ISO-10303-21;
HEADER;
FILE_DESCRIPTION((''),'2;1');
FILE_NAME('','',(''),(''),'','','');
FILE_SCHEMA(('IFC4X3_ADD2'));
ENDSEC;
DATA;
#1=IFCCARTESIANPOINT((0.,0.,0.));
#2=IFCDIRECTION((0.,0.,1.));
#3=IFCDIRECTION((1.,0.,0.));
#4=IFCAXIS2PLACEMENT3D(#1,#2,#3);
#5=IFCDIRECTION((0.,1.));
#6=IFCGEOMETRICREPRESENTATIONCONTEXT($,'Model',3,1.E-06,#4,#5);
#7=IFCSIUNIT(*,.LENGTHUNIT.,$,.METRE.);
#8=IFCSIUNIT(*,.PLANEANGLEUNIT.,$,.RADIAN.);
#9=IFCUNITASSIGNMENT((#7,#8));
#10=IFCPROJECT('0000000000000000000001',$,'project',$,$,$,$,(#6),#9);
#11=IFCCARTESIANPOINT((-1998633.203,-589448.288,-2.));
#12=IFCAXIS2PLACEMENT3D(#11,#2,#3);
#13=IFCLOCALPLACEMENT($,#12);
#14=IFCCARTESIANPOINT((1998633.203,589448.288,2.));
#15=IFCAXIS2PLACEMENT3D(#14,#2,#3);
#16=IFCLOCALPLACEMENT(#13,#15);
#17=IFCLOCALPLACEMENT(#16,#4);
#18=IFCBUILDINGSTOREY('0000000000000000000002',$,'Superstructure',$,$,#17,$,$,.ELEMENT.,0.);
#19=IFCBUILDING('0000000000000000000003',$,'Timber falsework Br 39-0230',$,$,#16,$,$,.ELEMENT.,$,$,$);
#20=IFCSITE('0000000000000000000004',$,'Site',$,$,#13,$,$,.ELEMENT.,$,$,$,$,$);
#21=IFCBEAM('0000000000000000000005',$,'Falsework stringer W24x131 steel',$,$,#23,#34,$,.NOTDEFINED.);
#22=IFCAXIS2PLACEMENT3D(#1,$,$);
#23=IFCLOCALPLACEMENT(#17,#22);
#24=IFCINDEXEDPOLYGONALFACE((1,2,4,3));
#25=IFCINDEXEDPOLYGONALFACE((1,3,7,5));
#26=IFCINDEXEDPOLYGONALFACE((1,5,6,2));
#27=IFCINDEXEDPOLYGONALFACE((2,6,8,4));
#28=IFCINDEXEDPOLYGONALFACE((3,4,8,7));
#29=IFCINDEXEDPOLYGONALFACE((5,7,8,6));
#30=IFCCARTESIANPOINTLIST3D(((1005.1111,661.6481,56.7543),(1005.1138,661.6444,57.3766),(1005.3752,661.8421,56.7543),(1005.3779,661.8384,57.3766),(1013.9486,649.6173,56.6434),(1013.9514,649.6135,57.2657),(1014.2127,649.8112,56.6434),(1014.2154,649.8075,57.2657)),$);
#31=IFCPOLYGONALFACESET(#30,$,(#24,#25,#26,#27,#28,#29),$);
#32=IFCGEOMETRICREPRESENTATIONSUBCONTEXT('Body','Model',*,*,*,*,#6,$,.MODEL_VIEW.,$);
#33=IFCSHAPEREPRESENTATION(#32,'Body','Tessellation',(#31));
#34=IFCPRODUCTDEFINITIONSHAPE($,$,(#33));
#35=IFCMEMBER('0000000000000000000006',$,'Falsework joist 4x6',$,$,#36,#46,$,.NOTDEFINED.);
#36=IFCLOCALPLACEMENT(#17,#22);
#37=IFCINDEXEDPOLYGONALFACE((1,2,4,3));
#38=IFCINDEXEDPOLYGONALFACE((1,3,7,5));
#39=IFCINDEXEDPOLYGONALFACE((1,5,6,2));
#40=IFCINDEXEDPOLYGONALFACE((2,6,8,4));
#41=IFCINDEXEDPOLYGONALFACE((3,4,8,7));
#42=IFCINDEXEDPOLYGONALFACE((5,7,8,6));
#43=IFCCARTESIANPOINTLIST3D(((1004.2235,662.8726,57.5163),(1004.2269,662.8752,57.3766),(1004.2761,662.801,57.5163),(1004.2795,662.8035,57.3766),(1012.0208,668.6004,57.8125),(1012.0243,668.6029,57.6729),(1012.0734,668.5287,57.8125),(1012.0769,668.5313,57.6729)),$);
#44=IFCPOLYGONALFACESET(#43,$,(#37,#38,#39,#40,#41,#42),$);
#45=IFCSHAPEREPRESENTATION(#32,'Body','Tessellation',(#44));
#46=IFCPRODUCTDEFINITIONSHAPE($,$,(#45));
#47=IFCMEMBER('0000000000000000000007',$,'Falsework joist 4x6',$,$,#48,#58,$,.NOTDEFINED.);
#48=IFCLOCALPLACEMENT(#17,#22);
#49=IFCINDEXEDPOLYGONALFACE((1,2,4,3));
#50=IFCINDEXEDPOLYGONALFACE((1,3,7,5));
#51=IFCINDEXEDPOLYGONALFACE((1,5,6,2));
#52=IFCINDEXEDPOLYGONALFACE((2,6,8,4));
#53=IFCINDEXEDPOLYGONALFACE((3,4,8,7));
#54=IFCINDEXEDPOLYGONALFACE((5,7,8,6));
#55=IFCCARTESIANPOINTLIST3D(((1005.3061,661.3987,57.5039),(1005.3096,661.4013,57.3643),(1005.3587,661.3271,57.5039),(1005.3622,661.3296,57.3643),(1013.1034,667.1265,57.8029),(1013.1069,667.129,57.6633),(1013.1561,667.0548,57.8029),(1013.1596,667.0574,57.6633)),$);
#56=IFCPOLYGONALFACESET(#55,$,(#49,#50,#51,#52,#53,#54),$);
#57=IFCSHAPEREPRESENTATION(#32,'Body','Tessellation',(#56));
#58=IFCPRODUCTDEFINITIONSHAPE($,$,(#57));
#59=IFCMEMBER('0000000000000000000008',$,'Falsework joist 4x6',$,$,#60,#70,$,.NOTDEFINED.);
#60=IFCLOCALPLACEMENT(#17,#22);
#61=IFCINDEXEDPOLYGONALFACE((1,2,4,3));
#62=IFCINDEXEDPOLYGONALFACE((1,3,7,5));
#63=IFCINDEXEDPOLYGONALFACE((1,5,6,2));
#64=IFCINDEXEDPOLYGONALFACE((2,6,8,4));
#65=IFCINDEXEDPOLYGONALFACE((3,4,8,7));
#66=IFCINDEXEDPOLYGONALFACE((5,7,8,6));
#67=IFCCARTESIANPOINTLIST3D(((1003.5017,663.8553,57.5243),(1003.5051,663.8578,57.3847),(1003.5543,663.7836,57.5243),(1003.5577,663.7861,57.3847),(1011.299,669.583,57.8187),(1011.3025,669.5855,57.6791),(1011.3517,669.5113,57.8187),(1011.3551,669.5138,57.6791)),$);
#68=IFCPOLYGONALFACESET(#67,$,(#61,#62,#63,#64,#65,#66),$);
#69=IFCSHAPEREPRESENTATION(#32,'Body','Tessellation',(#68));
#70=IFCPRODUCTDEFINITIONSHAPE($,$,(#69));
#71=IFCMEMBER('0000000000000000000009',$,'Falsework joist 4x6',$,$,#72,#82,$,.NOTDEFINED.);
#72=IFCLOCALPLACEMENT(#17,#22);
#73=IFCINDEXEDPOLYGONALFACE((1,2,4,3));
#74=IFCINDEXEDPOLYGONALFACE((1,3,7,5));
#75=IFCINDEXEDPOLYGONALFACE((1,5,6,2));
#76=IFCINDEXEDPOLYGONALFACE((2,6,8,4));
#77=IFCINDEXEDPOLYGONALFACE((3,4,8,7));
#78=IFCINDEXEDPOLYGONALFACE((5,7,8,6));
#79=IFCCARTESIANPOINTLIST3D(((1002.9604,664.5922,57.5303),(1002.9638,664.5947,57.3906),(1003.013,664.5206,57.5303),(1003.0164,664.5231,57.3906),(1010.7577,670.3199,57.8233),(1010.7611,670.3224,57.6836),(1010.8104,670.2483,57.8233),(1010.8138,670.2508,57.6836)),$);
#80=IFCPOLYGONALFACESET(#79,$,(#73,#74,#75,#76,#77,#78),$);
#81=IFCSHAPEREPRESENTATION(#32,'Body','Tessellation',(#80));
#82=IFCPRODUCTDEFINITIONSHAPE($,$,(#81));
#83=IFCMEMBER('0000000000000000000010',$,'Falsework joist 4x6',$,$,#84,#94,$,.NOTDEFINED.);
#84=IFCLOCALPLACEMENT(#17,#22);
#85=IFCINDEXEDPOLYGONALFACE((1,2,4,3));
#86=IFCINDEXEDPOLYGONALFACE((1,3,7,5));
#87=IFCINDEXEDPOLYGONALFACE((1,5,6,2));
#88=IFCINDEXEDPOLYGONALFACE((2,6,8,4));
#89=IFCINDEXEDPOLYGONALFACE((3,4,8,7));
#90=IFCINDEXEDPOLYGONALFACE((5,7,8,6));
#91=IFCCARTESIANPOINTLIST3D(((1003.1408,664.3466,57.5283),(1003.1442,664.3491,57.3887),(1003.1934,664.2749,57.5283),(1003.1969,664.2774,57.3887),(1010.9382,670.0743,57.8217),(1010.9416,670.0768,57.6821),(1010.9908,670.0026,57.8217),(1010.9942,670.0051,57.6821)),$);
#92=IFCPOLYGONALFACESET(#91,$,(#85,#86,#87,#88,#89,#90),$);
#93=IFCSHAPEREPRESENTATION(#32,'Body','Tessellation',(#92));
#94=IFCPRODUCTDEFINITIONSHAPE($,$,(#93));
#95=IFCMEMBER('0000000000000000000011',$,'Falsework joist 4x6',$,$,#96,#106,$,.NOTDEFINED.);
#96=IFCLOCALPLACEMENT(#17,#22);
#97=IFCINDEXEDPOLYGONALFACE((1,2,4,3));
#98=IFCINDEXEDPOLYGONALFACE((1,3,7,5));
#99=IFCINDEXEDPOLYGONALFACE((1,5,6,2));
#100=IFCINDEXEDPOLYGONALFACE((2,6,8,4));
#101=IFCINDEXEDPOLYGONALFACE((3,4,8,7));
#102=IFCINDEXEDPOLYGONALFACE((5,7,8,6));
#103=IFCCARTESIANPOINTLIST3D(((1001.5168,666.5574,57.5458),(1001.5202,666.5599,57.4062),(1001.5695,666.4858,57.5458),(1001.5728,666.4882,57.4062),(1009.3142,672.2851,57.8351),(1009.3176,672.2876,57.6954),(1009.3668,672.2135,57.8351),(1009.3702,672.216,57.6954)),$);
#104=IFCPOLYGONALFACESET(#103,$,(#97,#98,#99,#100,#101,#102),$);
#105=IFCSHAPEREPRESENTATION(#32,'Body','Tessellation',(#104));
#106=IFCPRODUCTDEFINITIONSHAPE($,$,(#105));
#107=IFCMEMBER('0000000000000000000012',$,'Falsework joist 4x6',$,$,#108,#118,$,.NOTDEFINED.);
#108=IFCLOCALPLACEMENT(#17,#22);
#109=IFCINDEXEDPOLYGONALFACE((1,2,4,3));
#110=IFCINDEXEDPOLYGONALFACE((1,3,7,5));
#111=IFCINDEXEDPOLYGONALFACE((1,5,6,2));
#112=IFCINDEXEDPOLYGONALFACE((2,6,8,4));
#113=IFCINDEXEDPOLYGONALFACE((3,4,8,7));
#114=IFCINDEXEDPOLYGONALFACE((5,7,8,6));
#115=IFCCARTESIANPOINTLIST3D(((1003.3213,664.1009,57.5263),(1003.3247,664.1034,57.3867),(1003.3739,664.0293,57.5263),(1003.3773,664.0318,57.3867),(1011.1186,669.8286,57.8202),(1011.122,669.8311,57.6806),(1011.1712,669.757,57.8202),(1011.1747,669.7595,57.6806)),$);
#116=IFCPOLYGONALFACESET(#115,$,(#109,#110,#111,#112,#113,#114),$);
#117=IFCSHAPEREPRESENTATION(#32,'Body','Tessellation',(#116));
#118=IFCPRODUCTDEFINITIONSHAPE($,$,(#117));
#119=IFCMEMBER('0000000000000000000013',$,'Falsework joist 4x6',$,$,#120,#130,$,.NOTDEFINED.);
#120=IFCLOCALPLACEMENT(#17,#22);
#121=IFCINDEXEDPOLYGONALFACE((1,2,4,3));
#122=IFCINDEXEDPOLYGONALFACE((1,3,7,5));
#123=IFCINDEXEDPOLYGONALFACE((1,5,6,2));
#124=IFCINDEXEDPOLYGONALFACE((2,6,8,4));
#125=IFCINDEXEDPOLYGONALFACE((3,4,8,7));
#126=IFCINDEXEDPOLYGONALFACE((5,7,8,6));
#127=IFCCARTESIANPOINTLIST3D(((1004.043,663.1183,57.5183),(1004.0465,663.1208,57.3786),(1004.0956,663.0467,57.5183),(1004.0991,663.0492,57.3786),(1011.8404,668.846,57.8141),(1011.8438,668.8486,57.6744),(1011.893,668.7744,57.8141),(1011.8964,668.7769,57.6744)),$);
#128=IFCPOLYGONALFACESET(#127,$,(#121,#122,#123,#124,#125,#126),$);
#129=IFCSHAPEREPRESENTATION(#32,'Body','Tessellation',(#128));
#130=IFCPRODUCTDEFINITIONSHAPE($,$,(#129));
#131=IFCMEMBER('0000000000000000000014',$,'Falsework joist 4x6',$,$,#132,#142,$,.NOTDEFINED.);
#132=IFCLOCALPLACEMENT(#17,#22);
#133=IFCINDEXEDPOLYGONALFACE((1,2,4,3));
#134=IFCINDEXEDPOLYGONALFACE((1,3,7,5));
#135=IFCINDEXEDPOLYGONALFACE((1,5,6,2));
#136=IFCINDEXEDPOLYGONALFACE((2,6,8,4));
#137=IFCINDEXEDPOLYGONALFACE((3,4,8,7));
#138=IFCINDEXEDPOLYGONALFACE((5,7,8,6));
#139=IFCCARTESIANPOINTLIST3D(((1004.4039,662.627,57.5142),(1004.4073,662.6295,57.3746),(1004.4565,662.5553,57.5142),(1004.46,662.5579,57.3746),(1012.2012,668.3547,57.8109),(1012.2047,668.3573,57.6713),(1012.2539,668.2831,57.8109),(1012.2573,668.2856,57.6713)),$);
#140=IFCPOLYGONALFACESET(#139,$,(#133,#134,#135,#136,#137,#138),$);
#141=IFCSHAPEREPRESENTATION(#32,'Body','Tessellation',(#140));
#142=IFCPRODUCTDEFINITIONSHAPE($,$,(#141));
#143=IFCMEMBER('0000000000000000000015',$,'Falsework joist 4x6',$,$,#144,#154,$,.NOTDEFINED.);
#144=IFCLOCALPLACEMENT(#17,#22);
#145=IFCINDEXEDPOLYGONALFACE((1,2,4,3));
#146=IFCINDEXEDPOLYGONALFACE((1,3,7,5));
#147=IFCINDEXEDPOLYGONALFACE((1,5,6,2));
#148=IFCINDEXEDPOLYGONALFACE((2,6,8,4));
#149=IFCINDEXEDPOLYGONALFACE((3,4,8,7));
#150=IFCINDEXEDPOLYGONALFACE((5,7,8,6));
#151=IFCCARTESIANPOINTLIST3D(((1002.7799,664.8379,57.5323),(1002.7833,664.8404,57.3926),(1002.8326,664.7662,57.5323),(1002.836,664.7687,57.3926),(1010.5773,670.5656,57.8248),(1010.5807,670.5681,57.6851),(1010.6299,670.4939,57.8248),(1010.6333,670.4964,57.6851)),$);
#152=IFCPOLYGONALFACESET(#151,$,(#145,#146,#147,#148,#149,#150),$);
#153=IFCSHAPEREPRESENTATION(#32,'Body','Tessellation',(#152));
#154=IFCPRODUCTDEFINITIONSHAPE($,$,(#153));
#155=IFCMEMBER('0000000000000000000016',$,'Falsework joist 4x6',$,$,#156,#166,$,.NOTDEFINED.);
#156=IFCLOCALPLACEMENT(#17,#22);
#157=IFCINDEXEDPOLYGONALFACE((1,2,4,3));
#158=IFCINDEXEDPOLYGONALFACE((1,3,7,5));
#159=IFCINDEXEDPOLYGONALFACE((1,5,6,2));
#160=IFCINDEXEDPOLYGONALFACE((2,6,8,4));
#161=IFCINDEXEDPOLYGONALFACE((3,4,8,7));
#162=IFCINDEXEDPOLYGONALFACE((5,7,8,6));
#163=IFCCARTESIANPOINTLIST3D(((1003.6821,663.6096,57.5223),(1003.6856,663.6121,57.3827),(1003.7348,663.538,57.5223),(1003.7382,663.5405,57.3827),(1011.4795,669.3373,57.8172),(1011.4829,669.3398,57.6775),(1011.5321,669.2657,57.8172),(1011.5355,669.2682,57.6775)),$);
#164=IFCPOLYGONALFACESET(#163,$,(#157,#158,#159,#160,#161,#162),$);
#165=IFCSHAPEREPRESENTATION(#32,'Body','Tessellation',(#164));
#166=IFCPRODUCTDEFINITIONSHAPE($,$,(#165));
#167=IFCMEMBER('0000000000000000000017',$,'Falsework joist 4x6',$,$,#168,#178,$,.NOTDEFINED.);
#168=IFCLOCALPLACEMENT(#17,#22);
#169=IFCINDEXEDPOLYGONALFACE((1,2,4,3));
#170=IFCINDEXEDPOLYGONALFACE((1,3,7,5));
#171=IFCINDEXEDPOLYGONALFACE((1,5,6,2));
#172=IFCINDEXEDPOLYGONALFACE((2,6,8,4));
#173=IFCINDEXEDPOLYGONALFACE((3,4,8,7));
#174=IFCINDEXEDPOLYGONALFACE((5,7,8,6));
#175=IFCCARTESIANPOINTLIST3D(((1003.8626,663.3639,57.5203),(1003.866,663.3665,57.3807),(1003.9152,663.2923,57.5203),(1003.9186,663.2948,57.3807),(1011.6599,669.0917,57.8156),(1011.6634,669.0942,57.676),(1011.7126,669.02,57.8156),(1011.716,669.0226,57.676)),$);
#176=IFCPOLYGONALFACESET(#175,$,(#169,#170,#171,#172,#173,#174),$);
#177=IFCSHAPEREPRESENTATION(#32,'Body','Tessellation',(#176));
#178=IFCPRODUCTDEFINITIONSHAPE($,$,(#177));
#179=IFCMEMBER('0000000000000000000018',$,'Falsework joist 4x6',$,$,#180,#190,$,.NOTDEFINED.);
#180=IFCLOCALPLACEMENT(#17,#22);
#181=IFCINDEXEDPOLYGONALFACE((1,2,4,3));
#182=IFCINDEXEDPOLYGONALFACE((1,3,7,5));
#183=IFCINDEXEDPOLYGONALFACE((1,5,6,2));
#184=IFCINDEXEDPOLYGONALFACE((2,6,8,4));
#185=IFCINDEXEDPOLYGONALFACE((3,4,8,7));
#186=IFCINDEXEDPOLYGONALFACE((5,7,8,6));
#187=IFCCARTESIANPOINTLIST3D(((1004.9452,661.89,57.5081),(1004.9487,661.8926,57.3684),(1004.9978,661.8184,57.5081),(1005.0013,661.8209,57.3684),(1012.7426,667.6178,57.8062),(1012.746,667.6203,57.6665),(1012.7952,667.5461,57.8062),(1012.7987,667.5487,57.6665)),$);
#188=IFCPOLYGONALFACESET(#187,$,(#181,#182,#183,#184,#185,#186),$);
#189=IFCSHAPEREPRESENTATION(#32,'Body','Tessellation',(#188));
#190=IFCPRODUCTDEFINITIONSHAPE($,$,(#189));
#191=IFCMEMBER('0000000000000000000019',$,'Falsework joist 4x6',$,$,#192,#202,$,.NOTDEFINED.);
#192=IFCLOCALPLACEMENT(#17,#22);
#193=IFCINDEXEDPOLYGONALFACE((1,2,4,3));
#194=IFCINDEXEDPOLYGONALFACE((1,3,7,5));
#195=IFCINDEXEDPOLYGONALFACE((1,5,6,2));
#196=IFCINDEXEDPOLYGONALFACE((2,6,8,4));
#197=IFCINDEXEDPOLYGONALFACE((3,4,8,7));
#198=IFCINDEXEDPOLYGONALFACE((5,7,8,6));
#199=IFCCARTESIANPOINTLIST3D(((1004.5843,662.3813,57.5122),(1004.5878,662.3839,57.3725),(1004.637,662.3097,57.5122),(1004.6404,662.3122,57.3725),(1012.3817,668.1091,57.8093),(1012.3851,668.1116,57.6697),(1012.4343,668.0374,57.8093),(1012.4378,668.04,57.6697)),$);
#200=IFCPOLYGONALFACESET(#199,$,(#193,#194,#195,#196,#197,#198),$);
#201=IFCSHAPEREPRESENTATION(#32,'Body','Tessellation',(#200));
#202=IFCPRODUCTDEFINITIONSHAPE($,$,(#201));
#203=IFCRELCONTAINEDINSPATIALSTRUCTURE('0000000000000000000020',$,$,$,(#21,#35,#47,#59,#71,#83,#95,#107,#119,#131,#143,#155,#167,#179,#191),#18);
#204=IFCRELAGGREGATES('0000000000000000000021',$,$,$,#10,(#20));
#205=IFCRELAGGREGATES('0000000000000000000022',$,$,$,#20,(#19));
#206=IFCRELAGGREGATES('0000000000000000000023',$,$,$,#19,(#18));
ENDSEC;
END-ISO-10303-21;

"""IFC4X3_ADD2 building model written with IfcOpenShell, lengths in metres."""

from ifc_helpers import new_model, si_unit, direction, frame, frame_2d, origin, origin_with_axes, place, context, subcontext, project, spatial, rectangle, extrude, element, save


model = new_model("IFC4X3_ADD2")

# Units and contexts
model_context = context("Model", 3, precision=1e-06, world=origin_with_axes(), true_north=direction((0.0, 1.0)))
body_context = subcontext(model_context, "Body", "Model", "MODEL_VIEW")
ifc_project = project(units=[si_unit("LENGTHUNIT", "METRE"), si_unit("PLANEANGLEUNIT", "RADIAN")], contexts=[model_context])

# Site, building, storey
site_placement = place(None, frame((-1998633.203, -589448.288, -2.0), z_axis=(0.0, 0.0, 1.0), x_axis=(1.0, 0.0, 0.0)))
site = spatial("IfcSite", under=ifc_project, at=site_placement, Name="Site", CompositionType="ELEMENT")
building_placement = place(site_placement, frame((1998633.203, 589448.288, 2.0), z_axis=(0.0, 0.0, 1.0), x_axis=(1.0, 0.0, 0.0)))
building = spatial("IfcBuilding", under=site, at=building_placement, Name="Timber falsework Br 39-0230", CompositionType="ELEMENT")
storey_placement = place(building_placement, origin_with_axes())
storey = spatial("IfcBuildingStorey", under=building, at=storey_placement, Name="Superstructure", CompositionType="ELEMENT", Elevation=0.0)

# Beam
beam_placement = place(storey_placement, frame((1005.2431, 661.7451, 56.7543), z_axis=(0.591997, -0.805906, -0.007427), x_axis=(0.805928, 0.592013, 0.0)))
element("IfcBeam", 1, at=beam_placement, inside=storey, Name="Falsework stringer W24x131 steel", PredefinedType="NOTDEFINED", context=body_context, shape_type="SweptSolid", body=[
    extrude(rectangle(XDim=0.3277, YDim=0.6223, at=frame_2d((0.0, 0.3111))), origin(), (0.0, 0.0, 1.0), 14.9284),
])

# Members
member_1_placement = place(storey_placement, frame((1004.2532, 662.8394, 57.3766), z_axis=(0.805551, 0.591736, 0.030604), x_axis=(-0.592013, 0.805928, 0.0)))
element("IfcMember", 2, at=member_1_placement, inside=storey, Name="Falsework joist 4x6", PredefinedType="NOTDEFINED", context=body_context, shape_type="SweptSolid", body=[
    extrude(rectangle(XDim=0.0889, YDim=0.1397, at=frame_2d((0.0, 0.0698))), origin(), (0.0, 0.0, 1.0), 9.6795),
])
member_2_placement = place(storey_placement, frame((1005.3359, 661.3655, 57.3643), z_axis=(0.805544, 0.591731, 0.030893), x_axis=(-0.592013, 0.805928, 0.0)))
element("IfcMember", 3, at=member_2_placement, inside=storey, Name="Falsework joist 4x6", PredefinedType="NOTDEFINED", context=body_context, shape_type="SweptSolid", body=[
    extrude(rectangle(XDim=0.0889, YDim=0.1397, at=frame_2d((0.0, 0.0698))), origin(), (0.0, 0.0, 1.0), 9.6796),
])
member_3_placement = place(storey_placement, frame((1003.5314, 663.8219, 57.3847), z_axis=(0.805555, 0.591739, 0.030412), x_axis=(-0.592013, 0.805928, 0.0)))
element("IfcMember", 4, at=member_3_placement, inside=storey, Name="Falsework joist 4x6", PredefinedType="NOTDEFINED", context=body_context, shape_type="SweptSolid", body=[
    extrude(rectangle(XDim=0.0889, YDim=0.1397, at=frame_2d((0.0, 0.0698))), origin(), (0.0, 0.0, 1.0), 9.6795),
])
member_4_placement = place(storey_placement, frame((1002.9901, 664.5589, 57.3906), z_axis=(0.805559, 0.591742, 0.030268), x_axis=(-0.592013, 0.805928, 0.0)))
element("IfcMember", 5, at=member_4_placement, inside=storey, Name="Falsework joist 4x6", PredefinedType="NOTDEFINED", context=body_context, shape_type="SweptSolid", body=[
    extrude(rectangle(XDim=0.0889, YDim=0.1397, at=frame_2d((0.0, 0.0698))), origin(), (0.0, 0.0, 1.0), 9.6794),
])
member_5_placement = place(storey_placement, frame((1003.1705, 664.3132, 57.3887), z_axis=(0.805558, 0.591741, 0.030316), x_axis=(-0.592013, 0.805928, 0.0)))
element("IfcMember", 6, at=member_5_placement, inside=storey, Name="Falsework joist 4x6", PredefinedType="NOTDEFINED", context=body_context, shape_type="SweptSolid", body=[
    extrude(rectangle(XDim=0.0889, YDim=0.1397, at=frame_2d((0.0, 0.0698))), origin(), (0.0, 0.0, 1.0), 9.6794),
])
member_6_placement = place(storey_placement, frame((1001.5465, 666.5241, 57.4062), z_axis=(0.805568, 0.591749, 0.029883), x_axis=(-0.592013, 0.805928, 0.0)))
element("IfcMember", 7, at=member_6_placement, inside=storey, Name="Falsework joist 4x6", PredefinedType="NOTDEFINED", context=body_context, shape_type="SweptSolid", body=[
    extrude(rectangle(XDim=0.0889, YDim=0.1397, at=frame_2d((0.0, 0.0698))), origin(), (0.0, 0.0, 1.0), 9.6793),
])
member_7_placement = place(storey_placement, frame((1003.351, 664.0676, 57.3867), z_axis=(0.805557, 0.59174, 0.030364), x_axis=(-0.592013, 0.805928, 0.0)))
element("IfcMember", 8, at=member_7_placement, inside=storey, Name="Falsework joist 4x6", PredefinedType="NOTDEFINED", context=body_context, shape_type="SweptSolid", body=[
    extrude(rectangle(XDim=0.0889, YDim=0.1397, at=frame_2d((0.0, 0.0698))), origin(), (0.0, 0.0, 1.0), 9.6795),
])
member_8_placement = place(storey_placement, frame((1004.0728, 663.085, 57.3786), z_axis=(0.805552, 0.591737, 0.030556), x_axis=(-0.592013, 0.805928, 0.0)))
element("IfcMember", 9, at=member_8_placement, inside=storey, Name="Falsework joist 4x6", PredefinedType="NOTDEFINED", context=body_context, shape_type="SweptSolid", body=[
    extrude(rectangle(XDim=0.0889, YDim=0.1397, at=frame_2d((0.0, 0.0698))), origin(), (0.0, 0.0, 1.0), 9.6795),
])
member_9_placement = place(storey_placement, frame((1004.4337, 662.5937, 57.3746), z_axis=(0.80555, 0.591735, 0.030652), x_axis=(-0.592013, 0.805928, 0.0)))
element("IfcMember", 10, at=member_9_placement, inside=storey, Name="Falsework joist 4x6", PredefinedType="NOTDEFINED", context=body_context, shape_type="SweptSolid", body=[
    extrude(rectangle(XDim=0.0889, YDim=0.1397, at=frame_2d((0.0, 0.0698))), origin(), (0.0, 0.0, 1.0), 9.6795),
])
member_10_placement = place(storey_placement, frame((1002.8096, 664.8045, 57.3926), z_axis=(0.80556, 0.591743, 0.03022), x_axis=(-0.592013, 0.805928, 0.0)))
element("IfcMember", 11, at=member_10_placement, inside=storey, Name="Falsework joist 4x6", PredefinedType="NOTDEFINED", context=body_context, shape_type="SweptSolid", body=[
    extrude(rectangle(XDim=0.0889, YDim=0.1397, at=frame_2d((0.0, 0.0698))), origin(), (0.0, 0.0, 1.0), 9.6794),
])
member_11_placement = place(storey_placement, frame((1003.7119, 663.5763, 57.3827), z_axis=(0.805554, 0.591738, 0.03046), x_axis=(-0.592013, 0.805928, 0.0)))
element("IfcMember", 12, at=member_11_placement, inside=storey, Name="Falsework joist 4x6", PredefinedType="NOTDEFINED", context=body_context, shape_type="SweptSolid", body=[
    extrude(rectangle(XDim=0.0889, YDim=0.1397, at=frame_2d((0.0, 0.0698))), origin(), (0.0, 0.0, 1.0), 9.6795),
])
member_12_placement = place(storey_placement, frame((1003.8923, 663.3306, 57.3807), z_axis=(0.805553, 0.591738, 0.030508), x_axis=(-0.592013, 0.805928, 0.0)))
element("IfcMember", 13, at=member_12_placement, inside=storey, Name="Falsework joist 4x6", PredefinedType="NOTDEFINED", context=body_context, shape_type="SweptSolid", body=[
    extrude(rectangle(XDim=0.0889, YDim=0.1397, at=frame_2d((0.0, 0.0698))), origin(), (0.0, 0.0, 1.0), 9.6795),
])
member_13_placement = place(storey_placement, frame((1004.975, 661.8568, 57.3684), z_axis=(0.805546, 0.591732, 0.030796), x_axis=(-0.592013, 0.805928, 0.0)))
element("IfcMember", 14, at=member_13_placement, inside=storey, Name="Falsework joist 4x6", PredefinedType="NOTDEFINED", context=body_context, shape_type="SweptSolid", body=[
    extrude(rectangle(XDim=0.0889, YDim=0.1397, at=frame_2d((0.0, 0.0698))), origin(), (0.0, 0.0, 1.0), 9.6796),
])
member_14_placement = place(storey_placement, frame((1004.6141, 662.3481, 57.3725), z_axis=(0.805548, 0.591734, 0.0307), x_axis=(-0.592013, 0.805928, 0.0)))
element("IfcMember", 15, at=member_14_placement, inside=storey, Name="Falsework joist 4x6", PredefinedType="NOTDEFINED", context=body_context, shape_type="SweptSolid", body=[
    extrude(rectangle(XDim=0.0889, YDim=0.1397, at=frame_2d((0.0, 0.0698))), origin(), (0.0, 0.0, 1.0), 9.6796),
])

save(model, "model.ifc")
